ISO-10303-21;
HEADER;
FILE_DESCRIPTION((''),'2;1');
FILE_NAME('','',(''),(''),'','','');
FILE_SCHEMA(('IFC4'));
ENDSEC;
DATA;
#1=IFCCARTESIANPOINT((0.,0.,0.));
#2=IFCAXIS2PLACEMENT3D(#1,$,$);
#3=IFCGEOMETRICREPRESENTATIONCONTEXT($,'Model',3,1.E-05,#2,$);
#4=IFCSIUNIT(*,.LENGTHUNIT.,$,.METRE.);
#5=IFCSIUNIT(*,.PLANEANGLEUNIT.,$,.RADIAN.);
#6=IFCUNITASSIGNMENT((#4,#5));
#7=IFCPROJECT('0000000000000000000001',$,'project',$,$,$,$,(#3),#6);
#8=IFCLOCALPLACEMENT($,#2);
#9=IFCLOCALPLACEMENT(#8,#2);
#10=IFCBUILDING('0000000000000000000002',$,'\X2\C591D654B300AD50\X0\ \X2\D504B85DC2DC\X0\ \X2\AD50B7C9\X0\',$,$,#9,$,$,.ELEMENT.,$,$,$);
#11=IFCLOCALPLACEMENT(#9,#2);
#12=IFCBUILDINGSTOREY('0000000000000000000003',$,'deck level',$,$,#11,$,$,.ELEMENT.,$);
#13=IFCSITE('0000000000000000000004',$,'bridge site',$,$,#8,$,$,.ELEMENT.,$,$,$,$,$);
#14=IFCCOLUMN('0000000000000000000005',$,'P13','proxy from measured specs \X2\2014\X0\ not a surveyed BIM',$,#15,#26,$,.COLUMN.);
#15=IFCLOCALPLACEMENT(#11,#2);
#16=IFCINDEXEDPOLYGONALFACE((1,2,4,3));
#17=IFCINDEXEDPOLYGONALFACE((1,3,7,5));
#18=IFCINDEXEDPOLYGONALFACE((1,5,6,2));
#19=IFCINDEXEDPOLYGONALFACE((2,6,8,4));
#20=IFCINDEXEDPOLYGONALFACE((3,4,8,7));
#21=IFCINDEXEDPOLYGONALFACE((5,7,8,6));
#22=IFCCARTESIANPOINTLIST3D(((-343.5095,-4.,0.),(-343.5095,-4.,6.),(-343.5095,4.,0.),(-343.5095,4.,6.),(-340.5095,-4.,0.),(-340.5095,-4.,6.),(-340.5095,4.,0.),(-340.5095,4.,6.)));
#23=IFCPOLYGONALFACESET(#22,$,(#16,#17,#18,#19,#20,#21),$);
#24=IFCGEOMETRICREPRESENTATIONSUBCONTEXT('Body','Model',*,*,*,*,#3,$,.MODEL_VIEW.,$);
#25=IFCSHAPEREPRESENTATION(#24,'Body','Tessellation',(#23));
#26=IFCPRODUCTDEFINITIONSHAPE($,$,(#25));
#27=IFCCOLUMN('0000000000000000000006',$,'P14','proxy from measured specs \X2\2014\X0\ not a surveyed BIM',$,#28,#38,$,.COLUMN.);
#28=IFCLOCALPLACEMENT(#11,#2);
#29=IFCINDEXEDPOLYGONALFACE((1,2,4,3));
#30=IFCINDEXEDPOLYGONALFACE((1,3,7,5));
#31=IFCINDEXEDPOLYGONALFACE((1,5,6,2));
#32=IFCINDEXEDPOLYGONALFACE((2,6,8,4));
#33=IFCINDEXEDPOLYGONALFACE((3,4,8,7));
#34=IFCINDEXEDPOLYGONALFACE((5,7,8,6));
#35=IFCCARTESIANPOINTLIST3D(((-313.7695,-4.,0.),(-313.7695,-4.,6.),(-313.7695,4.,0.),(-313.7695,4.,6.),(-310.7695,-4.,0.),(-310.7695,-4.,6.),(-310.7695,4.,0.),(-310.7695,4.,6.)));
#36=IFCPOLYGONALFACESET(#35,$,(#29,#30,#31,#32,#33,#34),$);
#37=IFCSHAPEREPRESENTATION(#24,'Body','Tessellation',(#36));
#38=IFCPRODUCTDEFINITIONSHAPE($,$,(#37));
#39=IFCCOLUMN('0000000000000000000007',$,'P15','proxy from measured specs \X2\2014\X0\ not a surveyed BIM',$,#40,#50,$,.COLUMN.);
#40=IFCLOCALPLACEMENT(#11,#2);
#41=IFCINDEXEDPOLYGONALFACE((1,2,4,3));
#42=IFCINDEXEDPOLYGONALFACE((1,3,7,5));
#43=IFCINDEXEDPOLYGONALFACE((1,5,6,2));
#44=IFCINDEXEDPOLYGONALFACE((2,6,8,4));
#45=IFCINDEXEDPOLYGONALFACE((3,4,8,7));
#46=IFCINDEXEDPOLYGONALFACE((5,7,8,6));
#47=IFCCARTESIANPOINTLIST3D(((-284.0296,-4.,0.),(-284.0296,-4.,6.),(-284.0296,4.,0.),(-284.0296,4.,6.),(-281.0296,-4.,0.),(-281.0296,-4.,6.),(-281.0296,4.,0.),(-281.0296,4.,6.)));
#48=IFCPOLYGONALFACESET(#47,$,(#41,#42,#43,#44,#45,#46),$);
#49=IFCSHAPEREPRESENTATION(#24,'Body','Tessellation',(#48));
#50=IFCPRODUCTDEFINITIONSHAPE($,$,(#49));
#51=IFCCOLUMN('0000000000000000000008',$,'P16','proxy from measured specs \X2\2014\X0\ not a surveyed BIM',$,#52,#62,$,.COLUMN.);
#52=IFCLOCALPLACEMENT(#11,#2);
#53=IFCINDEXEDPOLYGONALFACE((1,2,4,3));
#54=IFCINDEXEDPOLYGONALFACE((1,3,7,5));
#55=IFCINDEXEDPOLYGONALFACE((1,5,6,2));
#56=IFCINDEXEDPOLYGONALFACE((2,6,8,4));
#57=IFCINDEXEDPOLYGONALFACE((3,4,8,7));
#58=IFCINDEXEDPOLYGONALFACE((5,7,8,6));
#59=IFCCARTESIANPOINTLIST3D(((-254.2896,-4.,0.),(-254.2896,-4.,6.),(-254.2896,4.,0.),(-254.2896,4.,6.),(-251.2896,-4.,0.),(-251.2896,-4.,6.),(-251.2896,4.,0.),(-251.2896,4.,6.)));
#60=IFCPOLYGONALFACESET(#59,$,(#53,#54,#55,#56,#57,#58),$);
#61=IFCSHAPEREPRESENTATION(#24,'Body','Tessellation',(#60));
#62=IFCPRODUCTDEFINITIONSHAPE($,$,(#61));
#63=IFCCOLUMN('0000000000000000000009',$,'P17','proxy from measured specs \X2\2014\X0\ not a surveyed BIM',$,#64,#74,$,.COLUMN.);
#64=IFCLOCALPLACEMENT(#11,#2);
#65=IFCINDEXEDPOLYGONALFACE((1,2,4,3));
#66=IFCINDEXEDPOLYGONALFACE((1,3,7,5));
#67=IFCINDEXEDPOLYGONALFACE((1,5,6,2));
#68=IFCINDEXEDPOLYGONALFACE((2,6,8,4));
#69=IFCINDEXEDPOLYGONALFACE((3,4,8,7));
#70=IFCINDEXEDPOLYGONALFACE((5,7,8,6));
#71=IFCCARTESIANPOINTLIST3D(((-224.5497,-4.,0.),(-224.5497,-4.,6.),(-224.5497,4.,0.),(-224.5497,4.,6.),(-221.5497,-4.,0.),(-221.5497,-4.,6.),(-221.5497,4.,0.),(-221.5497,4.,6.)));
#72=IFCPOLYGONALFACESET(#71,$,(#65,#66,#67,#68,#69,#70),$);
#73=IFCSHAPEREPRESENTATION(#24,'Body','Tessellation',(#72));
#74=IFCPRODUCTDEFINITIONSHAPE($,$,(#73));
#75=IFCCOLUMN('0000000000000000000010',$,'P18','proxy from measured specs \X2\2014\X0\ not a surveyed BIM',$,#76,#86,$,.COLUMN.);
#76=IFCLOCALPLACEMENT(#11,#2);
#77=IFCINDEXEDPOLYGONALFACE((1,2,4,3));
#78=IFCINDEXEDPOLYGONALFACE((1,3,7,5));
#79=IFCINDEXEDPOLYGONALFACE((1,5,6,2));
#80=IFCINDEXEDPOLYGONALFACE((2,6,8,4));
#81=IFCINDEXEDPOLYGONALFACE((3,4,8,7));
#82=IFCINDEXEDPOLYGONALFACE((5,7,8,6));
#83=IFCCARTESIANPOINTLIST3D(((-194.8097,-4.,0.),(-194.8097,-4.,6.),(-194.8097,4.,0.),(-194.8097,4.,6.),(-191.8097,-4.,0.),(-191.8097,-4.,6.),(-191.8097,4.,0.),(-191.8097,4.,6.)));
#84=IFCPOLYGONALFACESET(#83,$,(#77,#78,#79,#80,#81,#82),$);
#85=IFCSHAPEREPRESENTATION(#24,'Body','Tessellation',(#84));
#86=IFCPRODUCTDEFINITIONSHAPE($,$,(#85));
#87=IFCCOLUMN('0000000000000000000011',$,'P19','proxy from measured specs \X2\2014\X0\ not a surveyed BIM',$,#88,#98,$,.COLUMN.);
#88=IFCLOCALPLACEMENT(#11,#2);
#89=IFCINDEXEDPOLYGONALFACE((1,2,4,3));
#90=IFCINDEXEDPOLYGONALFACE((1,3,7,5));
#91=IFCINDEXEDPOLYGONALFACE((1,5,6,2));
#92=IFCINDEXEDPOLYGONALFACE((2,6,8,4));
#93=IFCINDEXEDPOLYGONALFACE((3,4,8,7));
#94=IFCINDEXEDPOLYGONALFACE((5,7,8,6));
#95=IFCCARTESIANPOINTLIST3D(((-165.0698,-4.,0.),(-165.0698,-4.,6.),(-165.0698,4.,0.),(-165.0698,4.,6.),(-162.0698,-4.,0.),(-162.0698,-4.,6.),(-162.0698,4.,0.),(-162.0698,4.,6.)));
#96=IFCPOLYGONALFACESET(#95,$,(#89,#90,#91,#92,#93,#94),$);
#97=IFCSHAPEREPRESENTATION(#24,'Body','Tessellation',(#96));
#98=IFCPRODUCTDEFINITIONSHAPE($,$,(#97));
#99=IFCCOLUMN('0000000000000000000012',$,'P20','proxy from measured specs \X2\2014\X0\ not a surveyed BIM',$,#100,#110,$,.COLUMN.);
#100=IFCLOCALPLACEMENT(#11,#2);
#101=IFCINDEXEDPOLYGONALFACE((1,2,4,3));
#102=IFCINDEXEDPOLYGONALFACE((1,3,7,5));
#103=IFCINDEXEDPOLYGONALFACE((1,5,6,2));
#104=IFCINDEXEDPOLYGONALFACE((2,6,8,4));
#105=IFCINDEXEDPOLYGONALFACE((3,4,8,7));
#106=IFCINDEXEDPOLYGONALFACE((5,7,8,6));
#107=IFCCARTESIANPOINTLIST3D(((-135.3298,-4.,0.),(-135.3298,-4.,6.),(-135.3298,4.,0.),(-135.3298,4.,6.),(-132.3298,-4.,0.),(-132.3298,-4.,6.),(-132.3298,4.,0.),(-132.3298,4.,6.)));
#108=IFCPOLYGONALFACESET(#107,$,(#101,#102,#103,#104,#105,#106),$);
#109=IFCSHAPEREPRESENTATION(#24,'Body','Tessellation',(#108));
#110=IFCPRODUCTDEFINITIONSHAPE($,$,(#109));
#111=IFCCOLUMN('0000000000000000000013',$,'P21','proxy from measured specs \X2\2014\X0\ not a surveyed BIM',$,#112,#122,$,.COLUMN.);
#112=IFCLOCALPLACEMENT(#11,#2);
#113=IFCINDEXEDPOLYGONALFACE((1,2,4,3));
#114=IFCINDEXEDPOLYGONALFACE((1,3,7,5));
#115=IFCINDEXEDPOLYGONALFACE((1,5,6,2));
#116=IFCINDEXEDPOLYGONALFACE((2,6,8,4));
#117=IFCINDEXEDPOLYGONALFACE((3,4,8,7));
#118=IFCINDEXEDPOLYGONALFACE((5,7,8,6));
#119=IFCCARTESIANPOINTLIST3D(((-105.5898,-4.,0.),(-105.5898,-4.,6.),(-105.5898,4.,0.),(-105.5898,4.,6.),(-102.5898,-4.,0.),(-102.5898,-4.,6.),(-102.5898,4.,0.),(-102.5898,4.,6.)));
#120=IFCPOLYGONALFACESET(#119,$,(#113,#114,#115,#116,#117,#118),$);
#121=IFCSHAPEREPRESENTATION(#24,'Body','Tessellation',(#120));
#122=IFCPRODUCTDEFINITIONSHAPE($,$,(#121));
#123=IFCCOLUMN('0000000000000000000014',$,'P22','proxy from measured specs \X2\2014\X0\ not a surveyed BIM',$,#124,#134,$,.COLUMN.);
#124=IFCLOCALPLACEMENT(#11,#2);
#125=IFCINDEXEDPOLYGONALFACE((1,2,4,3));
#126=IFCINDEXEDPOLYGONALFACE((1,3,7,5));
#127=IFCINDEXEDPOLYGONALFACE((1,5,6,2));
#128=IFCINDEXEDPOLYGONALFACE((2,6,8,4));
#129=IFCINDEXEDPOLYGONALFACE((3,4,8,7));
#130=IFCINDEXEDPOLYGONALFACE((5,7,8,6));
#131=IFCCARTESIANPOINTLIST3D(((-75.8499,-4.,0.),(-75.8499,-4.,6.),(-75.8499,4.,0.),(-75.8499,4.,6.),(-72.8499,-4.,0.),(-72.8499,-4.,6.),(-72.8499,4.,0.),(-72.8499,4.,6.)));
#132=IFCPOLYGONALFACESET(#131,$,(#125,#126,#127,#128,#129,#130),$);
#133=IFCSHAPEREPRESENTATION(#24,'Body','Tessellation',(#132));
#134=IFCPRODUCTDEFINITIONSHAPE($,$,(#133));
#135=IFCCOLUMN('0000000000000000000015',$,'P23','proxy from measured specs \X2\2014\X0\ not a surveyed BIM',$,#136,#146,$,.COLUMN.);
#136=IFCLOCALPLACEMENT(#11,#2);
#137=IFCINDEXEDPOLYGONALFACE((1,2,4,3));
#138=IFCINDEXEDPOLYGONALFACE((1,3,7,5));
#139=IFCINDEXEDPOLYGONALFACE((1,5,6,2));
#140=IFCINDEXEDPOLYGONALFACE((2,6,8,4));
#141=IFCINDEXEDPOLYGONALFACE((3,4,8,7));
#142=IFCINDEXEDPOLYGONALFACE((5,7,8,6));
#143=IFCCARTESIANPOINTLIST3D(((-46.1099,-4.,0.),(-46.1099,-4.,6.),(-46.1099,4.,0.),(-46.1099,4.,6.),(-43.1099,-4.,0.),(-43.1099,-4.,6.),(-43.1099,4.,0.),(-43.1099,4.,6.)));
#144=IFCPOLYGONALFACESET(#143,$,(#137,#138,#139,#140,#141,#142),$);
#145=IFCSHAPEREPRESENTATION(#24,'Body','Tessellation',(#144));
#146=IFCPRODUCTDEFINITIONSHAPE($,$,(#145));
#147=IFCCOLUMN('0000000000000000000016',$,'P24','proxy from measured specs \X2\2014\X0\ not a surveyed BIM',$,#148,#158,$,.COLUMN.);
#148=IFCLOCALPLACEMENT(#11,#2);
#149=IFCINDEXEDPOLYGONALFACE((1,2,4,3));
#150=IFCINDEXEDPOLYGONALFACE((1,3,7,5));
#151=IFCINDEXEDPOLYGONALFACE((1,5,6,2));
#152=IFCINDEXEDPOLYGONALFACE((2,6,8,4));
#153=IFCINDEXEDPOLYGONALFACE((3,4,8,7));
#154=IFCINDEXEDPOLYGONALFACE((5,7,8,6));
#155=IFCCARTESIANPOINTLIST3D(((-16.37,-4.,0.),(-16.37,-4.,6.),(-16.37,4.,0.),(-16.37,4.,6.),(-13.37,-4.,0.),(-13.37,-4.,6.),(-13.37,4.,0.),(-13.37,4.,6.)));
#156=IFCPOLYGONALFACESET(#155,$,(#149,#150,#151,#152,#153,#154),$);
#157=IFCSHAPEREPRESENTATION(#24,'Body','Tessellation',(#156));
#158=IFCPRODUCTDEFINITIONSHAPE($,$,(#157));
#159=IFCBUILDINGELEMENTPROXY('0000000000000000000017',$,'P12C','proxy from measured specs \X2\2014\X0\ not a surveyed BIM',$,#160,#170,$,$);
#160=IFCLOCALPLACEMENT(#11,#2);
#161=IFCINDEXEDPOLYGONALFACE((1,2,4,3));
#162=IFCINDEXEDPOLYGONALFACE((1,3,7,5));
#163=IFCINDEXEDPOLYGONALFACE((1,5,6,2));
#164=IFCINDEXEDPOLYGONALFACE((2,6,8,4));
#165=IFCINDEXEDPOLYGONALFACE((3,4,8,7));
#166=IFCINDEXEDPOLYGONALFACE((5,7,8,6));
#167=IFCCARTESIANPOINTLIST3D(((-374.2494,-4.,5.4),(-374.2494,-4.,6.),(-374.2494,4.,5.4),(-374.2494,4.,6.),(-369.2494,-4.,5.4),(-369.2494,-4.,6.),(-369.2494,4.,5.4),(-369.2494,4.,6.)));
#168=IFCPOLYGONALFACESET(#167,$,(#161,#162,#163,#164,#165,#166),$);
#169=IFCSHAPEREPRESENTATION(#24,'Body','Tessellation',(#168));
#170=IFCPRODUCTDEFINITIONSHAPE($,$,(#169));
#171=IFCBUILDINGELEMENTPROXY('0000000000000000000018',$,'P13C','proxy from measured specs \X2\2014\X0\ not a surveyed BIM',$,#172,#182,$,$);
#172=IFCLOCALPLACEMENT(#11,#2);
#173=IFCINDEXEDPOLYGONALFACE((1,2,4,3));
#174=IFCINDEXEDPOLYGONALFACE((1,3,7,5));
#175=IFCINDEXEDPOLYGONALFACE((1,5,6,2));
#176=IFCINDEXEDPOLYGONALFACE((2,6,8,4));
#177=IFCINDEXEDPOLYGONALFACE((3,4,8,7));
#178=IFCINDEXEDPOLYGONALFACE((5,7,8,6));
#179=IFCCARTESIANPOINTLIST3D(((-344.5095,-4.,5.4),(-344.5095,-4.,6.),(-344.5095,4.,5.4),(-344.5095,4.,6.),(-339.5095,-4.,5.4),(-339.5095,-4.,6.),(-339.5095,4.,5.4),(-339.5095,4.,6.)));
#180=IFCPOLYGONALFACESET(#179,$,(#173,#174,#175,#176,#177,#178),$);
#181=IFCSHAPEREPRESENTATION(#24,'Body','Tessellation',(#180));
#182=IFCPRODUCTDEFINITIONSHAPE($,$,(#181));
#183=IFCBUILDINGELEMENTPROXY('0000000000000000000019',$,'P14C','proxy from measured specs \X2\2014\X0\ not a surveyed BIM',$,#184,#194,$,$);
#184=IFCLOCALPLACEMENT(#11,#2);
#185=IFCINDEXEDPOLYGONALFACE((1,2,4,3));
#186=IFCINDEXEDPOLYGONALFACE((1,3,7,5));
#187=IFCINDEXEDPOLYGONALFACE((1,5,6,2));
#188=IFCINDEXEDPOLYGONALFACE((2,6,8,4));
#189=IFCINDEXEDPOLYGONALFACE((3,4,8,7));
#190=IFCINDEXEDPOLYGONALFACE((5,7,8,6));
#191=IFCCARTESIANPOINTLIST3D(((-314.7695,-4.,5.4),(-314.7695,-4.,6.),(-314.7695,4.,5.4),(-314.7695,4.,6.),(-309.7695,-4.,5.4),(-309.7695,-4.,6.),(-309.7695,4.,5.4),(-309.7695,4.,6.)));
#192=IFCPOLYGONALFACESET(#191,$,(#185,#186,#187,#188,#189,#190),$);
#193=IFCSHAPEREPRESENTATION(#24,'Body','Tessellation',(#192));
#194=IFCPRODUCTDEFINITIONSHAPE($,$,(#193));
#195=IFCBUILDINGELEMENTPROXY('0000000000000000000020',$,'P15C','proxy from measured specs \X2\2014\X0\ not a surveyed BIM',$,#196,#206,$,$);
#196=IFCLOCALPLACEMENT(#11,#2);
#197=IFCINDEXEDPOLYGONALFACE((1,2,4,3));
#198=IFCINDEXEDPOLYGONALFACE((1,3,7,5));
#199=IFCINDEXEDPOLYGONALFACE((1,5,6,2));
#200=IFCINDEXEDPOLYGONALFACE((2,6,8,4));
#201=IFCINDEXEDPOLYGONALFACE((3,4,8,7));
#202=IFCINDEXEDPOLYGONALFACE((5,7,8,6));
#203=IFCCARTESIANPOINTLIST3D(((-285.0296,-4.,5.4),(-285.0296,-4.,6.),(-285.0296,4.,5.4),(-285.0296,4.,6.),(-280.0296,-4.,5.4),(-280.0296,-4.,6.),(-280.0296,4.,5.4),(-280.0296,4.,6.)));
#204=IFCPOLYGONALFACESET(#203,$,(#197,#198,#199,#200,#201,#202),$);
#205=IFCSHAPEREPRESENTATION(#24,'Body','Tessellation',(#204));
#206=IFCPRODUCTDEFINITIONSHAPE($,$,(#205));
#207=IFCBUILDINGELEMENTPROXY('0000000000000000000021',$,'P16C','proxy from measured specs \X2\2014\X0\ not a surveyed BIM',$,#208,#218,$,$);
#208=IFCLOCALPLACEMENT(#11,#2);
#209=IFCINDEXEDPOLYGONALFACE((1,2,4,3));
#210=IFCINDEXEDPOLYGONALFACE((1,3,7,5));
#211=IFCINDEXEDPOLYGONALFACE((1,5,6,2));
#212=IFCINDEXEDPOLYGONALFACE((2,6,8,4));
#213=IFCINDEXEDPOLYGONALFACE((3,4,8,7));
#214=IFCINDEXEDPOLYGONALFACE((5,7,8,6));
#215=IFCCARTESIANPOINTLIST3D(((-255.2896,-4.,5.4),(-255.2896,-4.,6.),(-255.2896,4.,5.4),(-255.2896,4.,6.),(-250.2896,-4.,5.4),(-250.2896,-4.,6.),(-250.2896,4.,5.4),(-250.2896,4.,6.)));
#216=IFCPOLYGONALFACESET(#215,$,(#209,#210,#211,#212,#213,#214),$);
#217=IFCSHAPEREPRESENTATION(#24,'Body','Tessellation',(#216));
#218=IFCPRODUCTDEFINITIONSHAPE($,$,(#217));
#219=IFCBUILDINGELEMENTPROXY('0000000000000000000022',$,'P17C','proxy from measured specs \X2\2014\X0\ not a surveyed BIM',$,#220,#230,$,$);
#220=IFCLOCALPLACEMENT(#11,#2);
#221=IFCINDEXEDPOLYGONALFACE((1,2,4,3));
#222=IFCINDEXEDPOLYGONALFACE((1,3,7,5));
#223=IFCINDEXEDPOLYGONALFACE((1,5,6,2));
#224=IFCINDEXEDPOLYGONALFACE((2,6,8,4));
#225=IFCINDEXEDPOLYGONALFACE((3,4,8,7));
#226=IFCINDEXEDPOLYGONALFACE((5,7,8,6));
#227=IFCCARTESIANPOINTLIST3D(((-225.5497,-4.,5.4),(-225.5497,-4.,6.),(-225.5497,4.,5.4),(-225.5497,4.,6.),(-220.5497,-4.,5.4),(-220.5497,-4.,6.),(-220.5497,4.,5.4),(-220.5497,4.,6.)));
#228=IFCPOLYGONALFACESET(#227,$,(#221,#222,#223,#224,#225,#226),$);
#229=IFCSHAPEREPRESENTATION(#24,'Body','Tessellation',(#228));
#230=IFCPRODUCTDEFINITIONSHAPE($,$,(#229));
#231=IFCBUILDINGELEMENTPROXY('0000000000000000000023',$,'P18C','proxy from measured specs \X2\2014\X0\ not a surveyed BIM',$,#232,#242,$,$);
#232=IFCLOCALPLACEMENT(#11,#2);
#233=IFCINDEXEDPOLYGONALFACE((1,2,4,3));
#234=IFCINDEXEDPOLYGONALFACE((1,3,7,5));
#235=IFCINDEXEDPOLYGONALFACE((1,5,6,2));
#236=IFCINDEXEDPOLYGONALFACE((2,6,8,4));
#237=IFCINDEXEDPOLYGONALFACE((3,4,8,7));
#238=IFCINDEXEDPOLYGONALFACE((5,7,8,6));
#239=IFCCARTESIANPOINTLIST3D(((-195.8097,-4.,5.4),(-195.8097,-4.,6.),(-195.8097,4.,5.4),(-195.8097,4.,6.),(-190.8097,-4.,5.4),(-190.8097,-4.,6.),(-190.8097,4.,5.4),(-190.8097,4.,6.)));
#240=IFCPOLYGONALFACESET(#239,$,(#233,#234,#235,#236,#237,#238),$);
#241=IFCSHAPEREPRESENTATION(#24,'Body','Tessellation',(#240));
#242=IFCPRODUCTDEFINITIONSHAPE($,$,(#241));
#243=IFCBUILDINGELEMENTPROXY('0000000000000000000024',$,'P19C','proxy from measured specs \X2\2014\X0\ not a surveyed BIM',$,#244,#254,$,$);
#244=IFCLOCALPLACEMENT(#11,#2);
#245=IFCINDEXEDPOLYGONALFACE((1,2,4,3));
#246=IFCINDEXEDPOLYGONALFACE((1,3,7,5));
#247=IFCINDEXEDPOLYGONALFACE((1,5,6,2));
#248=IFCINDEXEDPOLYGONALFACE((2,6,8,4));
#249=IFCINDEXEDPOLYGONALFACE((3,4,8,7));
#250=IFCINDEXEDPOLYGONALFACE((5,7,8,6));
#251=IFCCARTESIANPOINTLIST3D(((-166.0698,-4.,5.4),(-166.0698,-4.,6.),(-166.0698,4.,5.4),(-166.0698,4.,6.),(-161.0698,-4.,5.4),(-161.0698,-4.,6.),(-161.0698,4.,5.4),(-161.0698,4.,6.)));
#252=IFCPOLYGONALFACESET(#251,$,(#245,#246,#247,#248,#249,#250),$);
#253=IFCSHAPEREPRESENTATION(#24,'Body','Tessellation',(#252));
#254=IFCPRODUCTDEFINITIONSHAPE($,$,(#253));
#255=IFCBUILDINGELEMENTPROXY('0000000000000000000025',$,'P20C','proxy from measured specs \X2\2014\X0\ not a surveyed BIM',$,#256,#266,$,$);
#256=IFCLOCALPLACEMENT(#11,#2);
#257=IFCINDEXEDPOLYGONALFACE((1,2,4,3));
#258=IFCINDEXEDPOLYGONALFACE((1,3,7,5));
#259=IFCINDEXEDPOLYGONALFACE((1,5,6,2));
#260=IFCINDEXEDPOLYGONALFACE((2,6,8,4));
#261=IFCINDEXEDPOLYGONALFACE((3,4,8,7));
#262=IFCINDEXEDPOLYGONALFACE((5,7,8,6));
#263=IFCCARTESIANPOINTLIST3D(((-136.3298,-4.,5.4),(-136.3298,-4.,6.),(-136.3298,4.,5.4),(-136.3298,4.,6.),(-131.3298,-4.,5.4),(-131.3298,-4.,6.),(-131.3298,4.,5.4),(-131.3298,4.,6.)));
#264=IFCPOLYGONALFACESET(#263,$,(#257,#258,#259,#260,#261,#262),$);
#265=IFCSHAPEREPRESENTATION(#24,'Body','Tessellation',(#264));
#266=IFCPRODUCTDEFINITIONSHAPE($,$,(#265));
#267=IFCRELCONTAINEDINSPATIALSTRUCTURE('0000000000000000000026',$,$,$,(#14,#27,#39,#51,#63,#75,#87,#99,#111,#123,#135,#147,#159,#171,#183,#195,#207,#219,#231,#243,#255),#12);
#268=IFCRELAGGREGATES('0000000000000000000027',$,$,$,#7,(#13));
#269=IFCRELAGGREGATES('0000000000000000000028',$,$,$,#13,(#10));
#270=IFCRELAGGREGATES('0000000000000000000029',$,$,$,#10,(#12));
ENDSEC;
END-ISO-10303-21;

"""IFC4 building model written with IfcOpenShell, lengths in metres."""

from ifc_helpers import new_model, si_unit, frame, origin, origin_2d, place, context, subcontext, project, spatial, rectangle, extrude, element, save


model = new_model("IFC4")

# Units and contexts
model_context = context("Model", 3, precision=1e-05, world=origin())
body_context = subcontext(model_context, "Body", "Model", "MODEL_VIEW")
ifc_project = project(units=[si_unit("LENGTHUNIT", "METRE"), si_unit("PLANEANGLEUNIT", "RADIAN")], contexts=[model_context])

# Site, building, storey
site_placement = place(None, origin())
site = spatial("IfcSite", under=ifc_project, at=site_placement, Name="bridge site", CompositionType="ELEMENT")
building_placement = place(site_placement, origin())
building = spatial("IfcBuilding", under=site, at=building_placement, Name="양화대교 프록시 교량", CompositionType="ELEMENT")
storey_placement = place(building_placement, origin())
storey = spatial("IfcBuildingStorey", under=building, at=storey_placement, Name="deck level", CompositionType="ELEMENT")

# Columns
for number, where, name in (
    (1, (-342.0095, 0.0, 0.0), "P13"),
    (2, (-312.2695, 0.0, 0.0), "P14"),
    (3, (-282.5296, 0.0, 0.0), "P15"),
    (4, (-252.7896, 0.0, 0.0), "P16"),
    (5, (-223.0497, 0.0, 0.0), "P17"),
    (6, (-193.3097, 0.0, 0.0), "P18"),
    (7, (-163.5698, 0.0, 0.0), "P19"),
    (8, (-133.8298, 0.0, 0.0), "P20"),
    (9, (-104.0898, 0.0, 0.0), "P21"),
    (10, (-74.3499, 0.0, 0.0), "P22"),
    (11, (-44.6099, 0.0, 0.0), "P23"),
    (12, (-14.87, 0.0, 0.0), "P24"),
):
    element("IfcColumn", number, at=place(storey_placement, frame(where)), inside=storey, Name=name, Description="proxy from measured specs — not a surveyed BIM", PredefinedType="COLUMN", context=body_context, shape_type="SweptSolid", body=[
        extrude(rectangle(XDim=3.0, YDim=8.0, at=origin_2d()), origin(), (0.0, 0.0, 1.0), 6.0),
    ])

# Building element proxies
for number, where, name in (
    (13, (-371.7494, 0.0, 5.4), "P12C"),
    (14, (-342.0095, 0.0, 5.4), "P13C"),
    (15, (-312.2695, 0.0, 5.4), "P14C"),
    (16, (-282.5296, 0.0, 5.4), "P15C"),
    (17, (-252.7896, 0.0, 5.4), "P16C"),
    (18, (-223.0497, 0.0, 5.4), "P17C"),
    (19, (-193.3097, 0.0, 5.4), "P18C"),
    (20, (-163.5698, 0.0, 5.4), "P19C"),
    (21, (-133.8298, 0.0, 5.4), "P20C"),
):
    element("IfcBuildingElementProxy", number, at=place(storey_placement, frame(where)), inside=storey, Name=name, Description="proxy from measured specs — not a surveyed BIM", context=body_context, shape_type="SweptSolid", body=[
        extrude(rectangle(XDim=5.0, YDim=8.0, at=origin_2d()), origin(), (0.0, 0.0, 1.0), 0.6),
    ])

save(model, "model.ifc")
